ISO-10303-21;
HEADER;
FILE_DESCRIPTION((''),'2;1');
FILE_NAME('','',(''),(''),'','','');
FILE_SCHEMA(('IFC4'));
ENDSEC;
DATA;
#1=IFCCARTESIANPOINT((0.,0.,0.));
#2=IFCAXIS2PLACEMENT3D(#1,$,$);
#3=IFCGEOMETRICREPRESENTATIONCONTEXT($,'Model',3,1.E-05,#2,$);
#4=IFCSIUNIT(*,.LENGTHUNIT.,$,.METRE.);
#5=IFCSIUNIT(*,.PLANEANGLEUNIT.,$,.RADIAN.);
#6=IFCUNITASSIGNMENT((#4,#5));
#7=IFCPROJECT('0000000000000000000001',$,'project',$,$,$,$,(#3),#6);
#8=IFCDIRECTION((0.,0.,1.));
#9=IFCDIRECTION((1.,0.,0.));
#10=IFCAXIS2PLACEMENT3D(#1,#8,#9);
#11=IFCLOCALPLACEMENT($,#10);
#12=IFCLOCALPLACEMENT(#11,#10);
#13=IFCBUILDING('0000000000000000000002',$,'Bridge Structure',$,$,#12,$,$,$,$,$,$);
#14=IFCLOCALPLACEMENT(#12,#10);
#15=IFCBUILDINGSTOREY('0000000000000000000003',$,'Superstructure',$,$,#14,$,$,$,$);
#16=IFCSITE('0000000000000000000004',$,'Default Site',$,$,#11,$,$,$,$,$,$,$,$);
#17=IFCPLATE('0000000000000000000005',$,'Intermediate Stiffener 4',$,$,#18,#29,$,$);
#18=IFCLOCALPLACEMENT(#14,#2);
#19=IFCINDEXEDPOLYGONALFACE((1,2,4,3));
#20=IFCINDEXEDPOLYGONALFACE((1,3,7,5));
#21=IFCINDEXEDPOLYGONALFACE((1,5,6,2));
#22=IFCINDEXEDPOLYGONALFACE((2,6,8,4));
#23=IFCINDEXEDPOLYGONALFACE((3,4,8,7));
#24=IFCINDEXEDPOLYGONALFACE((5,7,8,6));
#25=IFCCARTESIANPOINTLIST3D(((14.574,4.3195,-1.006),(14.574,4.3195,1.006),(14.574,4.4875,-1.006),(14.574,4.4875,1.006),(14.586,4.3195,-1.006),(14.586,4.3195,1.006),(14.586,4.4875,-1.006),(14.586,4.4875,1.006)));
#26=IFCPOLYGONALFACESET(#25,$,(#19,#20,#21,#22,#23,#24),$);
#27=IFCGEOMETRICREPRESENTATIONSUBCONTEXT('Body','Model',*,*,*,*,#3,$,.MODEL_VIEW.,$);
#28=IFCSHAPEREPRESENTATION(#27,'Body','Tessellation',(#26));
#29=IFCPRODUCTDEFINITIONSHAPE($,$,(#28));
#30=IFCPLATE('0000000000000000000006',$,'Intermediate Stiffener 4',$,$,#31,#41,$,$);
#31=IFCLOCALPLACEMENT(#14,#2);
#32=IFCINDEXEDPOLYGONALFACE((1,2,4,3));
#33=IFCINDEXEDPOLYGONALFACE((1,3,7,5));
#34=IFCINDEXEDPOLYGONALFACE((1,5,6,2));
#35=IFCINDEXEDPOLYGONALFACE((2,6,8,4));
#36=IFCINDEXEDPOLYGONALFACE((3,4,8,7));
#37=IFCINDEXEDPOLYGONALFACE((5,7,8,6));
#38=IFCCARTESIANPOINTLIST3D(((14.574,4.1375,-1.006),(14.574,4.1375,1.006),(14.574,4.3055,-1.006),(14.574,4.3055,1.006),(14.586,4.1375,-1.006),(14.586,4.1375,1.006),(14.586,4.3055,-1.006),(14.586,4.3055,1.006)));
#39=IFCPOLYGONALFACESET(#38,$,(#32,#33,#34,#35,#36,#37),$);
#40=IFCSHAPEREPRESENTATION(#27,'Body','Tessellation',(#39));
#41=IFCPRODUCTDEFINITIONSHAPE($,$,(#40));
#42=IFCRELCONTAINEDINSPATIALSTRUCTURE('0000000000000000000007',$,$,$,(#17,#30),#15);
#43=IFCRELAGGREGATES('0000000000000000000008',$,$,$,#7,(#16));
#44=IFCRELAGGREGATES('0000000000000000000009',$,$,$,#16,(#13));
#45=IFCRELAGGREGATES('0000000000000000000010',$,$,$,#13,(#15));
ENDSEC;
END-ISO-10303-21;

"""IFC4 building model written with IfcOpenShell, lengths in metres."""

from ifc_helpers import new_model, si_unit, frame, origin, origin_with_axes, origin_2d_with_axis, place, context, subcontext, project, spatial, rectangle, extrude, element, save


model = new_model("IFC4")

# Units and contexts
model_context = context("Model", 3, precision=1e-05, world=origin())
body_context = subcontext(model_context, "Body", "Model", "MODEL_VIEW")
ifc_project = project(units=[si_unit("LENGTHUNIT", "METRE"), si_unit("PLANEANGLEUNIT", "RADIAN")], contexts=[model_context])

# Site, building, storey
site_placement = place(None, origin_with_axes())
site = spatial("IfcSite", under=ifc_project, at=site_placement, Name="Default Site")
building_placement = place(site_placement, origin_with_axes())
building = spatial("IfcBuilding", under=site, at=building_placement, Name="Bridge Structure")
storey_placement = place(building_placement, origin_with_axes())
storey = spatial("IfcBuildingStorey", under=building, at=storey_placement, Name="Superstructure")

# Plates
for number, where, z_axis, x_axis, name in (
    (1, (14.58, 4.4035, -1.006), (0.0, 0.0, 1.0), (1.0, 0.0, 0.0), "Intermediate Stiffener 4"),
    (2, (14.58, 4.2215, -1.006), (0.0, 0.0, 1.0), (1.0, 0.0, 0.0), "Intermediate Stiffener 4"),
):
    element("IfcPlate", number, at=place(storey_placement, frame(where, z_axis=z_axis, x_axis=x_axis)), inside=storey, Name=name, context=body_context, shape_type="SweptSolid", body=[
        extrude(rectangle(XDim=0.012, YDim=0.168, at=origin_2d_with_axis()), origin_with_axes(), (0.0, 0.0, 1.0), 2.012),
    ])

save(model, "model.ifc")
